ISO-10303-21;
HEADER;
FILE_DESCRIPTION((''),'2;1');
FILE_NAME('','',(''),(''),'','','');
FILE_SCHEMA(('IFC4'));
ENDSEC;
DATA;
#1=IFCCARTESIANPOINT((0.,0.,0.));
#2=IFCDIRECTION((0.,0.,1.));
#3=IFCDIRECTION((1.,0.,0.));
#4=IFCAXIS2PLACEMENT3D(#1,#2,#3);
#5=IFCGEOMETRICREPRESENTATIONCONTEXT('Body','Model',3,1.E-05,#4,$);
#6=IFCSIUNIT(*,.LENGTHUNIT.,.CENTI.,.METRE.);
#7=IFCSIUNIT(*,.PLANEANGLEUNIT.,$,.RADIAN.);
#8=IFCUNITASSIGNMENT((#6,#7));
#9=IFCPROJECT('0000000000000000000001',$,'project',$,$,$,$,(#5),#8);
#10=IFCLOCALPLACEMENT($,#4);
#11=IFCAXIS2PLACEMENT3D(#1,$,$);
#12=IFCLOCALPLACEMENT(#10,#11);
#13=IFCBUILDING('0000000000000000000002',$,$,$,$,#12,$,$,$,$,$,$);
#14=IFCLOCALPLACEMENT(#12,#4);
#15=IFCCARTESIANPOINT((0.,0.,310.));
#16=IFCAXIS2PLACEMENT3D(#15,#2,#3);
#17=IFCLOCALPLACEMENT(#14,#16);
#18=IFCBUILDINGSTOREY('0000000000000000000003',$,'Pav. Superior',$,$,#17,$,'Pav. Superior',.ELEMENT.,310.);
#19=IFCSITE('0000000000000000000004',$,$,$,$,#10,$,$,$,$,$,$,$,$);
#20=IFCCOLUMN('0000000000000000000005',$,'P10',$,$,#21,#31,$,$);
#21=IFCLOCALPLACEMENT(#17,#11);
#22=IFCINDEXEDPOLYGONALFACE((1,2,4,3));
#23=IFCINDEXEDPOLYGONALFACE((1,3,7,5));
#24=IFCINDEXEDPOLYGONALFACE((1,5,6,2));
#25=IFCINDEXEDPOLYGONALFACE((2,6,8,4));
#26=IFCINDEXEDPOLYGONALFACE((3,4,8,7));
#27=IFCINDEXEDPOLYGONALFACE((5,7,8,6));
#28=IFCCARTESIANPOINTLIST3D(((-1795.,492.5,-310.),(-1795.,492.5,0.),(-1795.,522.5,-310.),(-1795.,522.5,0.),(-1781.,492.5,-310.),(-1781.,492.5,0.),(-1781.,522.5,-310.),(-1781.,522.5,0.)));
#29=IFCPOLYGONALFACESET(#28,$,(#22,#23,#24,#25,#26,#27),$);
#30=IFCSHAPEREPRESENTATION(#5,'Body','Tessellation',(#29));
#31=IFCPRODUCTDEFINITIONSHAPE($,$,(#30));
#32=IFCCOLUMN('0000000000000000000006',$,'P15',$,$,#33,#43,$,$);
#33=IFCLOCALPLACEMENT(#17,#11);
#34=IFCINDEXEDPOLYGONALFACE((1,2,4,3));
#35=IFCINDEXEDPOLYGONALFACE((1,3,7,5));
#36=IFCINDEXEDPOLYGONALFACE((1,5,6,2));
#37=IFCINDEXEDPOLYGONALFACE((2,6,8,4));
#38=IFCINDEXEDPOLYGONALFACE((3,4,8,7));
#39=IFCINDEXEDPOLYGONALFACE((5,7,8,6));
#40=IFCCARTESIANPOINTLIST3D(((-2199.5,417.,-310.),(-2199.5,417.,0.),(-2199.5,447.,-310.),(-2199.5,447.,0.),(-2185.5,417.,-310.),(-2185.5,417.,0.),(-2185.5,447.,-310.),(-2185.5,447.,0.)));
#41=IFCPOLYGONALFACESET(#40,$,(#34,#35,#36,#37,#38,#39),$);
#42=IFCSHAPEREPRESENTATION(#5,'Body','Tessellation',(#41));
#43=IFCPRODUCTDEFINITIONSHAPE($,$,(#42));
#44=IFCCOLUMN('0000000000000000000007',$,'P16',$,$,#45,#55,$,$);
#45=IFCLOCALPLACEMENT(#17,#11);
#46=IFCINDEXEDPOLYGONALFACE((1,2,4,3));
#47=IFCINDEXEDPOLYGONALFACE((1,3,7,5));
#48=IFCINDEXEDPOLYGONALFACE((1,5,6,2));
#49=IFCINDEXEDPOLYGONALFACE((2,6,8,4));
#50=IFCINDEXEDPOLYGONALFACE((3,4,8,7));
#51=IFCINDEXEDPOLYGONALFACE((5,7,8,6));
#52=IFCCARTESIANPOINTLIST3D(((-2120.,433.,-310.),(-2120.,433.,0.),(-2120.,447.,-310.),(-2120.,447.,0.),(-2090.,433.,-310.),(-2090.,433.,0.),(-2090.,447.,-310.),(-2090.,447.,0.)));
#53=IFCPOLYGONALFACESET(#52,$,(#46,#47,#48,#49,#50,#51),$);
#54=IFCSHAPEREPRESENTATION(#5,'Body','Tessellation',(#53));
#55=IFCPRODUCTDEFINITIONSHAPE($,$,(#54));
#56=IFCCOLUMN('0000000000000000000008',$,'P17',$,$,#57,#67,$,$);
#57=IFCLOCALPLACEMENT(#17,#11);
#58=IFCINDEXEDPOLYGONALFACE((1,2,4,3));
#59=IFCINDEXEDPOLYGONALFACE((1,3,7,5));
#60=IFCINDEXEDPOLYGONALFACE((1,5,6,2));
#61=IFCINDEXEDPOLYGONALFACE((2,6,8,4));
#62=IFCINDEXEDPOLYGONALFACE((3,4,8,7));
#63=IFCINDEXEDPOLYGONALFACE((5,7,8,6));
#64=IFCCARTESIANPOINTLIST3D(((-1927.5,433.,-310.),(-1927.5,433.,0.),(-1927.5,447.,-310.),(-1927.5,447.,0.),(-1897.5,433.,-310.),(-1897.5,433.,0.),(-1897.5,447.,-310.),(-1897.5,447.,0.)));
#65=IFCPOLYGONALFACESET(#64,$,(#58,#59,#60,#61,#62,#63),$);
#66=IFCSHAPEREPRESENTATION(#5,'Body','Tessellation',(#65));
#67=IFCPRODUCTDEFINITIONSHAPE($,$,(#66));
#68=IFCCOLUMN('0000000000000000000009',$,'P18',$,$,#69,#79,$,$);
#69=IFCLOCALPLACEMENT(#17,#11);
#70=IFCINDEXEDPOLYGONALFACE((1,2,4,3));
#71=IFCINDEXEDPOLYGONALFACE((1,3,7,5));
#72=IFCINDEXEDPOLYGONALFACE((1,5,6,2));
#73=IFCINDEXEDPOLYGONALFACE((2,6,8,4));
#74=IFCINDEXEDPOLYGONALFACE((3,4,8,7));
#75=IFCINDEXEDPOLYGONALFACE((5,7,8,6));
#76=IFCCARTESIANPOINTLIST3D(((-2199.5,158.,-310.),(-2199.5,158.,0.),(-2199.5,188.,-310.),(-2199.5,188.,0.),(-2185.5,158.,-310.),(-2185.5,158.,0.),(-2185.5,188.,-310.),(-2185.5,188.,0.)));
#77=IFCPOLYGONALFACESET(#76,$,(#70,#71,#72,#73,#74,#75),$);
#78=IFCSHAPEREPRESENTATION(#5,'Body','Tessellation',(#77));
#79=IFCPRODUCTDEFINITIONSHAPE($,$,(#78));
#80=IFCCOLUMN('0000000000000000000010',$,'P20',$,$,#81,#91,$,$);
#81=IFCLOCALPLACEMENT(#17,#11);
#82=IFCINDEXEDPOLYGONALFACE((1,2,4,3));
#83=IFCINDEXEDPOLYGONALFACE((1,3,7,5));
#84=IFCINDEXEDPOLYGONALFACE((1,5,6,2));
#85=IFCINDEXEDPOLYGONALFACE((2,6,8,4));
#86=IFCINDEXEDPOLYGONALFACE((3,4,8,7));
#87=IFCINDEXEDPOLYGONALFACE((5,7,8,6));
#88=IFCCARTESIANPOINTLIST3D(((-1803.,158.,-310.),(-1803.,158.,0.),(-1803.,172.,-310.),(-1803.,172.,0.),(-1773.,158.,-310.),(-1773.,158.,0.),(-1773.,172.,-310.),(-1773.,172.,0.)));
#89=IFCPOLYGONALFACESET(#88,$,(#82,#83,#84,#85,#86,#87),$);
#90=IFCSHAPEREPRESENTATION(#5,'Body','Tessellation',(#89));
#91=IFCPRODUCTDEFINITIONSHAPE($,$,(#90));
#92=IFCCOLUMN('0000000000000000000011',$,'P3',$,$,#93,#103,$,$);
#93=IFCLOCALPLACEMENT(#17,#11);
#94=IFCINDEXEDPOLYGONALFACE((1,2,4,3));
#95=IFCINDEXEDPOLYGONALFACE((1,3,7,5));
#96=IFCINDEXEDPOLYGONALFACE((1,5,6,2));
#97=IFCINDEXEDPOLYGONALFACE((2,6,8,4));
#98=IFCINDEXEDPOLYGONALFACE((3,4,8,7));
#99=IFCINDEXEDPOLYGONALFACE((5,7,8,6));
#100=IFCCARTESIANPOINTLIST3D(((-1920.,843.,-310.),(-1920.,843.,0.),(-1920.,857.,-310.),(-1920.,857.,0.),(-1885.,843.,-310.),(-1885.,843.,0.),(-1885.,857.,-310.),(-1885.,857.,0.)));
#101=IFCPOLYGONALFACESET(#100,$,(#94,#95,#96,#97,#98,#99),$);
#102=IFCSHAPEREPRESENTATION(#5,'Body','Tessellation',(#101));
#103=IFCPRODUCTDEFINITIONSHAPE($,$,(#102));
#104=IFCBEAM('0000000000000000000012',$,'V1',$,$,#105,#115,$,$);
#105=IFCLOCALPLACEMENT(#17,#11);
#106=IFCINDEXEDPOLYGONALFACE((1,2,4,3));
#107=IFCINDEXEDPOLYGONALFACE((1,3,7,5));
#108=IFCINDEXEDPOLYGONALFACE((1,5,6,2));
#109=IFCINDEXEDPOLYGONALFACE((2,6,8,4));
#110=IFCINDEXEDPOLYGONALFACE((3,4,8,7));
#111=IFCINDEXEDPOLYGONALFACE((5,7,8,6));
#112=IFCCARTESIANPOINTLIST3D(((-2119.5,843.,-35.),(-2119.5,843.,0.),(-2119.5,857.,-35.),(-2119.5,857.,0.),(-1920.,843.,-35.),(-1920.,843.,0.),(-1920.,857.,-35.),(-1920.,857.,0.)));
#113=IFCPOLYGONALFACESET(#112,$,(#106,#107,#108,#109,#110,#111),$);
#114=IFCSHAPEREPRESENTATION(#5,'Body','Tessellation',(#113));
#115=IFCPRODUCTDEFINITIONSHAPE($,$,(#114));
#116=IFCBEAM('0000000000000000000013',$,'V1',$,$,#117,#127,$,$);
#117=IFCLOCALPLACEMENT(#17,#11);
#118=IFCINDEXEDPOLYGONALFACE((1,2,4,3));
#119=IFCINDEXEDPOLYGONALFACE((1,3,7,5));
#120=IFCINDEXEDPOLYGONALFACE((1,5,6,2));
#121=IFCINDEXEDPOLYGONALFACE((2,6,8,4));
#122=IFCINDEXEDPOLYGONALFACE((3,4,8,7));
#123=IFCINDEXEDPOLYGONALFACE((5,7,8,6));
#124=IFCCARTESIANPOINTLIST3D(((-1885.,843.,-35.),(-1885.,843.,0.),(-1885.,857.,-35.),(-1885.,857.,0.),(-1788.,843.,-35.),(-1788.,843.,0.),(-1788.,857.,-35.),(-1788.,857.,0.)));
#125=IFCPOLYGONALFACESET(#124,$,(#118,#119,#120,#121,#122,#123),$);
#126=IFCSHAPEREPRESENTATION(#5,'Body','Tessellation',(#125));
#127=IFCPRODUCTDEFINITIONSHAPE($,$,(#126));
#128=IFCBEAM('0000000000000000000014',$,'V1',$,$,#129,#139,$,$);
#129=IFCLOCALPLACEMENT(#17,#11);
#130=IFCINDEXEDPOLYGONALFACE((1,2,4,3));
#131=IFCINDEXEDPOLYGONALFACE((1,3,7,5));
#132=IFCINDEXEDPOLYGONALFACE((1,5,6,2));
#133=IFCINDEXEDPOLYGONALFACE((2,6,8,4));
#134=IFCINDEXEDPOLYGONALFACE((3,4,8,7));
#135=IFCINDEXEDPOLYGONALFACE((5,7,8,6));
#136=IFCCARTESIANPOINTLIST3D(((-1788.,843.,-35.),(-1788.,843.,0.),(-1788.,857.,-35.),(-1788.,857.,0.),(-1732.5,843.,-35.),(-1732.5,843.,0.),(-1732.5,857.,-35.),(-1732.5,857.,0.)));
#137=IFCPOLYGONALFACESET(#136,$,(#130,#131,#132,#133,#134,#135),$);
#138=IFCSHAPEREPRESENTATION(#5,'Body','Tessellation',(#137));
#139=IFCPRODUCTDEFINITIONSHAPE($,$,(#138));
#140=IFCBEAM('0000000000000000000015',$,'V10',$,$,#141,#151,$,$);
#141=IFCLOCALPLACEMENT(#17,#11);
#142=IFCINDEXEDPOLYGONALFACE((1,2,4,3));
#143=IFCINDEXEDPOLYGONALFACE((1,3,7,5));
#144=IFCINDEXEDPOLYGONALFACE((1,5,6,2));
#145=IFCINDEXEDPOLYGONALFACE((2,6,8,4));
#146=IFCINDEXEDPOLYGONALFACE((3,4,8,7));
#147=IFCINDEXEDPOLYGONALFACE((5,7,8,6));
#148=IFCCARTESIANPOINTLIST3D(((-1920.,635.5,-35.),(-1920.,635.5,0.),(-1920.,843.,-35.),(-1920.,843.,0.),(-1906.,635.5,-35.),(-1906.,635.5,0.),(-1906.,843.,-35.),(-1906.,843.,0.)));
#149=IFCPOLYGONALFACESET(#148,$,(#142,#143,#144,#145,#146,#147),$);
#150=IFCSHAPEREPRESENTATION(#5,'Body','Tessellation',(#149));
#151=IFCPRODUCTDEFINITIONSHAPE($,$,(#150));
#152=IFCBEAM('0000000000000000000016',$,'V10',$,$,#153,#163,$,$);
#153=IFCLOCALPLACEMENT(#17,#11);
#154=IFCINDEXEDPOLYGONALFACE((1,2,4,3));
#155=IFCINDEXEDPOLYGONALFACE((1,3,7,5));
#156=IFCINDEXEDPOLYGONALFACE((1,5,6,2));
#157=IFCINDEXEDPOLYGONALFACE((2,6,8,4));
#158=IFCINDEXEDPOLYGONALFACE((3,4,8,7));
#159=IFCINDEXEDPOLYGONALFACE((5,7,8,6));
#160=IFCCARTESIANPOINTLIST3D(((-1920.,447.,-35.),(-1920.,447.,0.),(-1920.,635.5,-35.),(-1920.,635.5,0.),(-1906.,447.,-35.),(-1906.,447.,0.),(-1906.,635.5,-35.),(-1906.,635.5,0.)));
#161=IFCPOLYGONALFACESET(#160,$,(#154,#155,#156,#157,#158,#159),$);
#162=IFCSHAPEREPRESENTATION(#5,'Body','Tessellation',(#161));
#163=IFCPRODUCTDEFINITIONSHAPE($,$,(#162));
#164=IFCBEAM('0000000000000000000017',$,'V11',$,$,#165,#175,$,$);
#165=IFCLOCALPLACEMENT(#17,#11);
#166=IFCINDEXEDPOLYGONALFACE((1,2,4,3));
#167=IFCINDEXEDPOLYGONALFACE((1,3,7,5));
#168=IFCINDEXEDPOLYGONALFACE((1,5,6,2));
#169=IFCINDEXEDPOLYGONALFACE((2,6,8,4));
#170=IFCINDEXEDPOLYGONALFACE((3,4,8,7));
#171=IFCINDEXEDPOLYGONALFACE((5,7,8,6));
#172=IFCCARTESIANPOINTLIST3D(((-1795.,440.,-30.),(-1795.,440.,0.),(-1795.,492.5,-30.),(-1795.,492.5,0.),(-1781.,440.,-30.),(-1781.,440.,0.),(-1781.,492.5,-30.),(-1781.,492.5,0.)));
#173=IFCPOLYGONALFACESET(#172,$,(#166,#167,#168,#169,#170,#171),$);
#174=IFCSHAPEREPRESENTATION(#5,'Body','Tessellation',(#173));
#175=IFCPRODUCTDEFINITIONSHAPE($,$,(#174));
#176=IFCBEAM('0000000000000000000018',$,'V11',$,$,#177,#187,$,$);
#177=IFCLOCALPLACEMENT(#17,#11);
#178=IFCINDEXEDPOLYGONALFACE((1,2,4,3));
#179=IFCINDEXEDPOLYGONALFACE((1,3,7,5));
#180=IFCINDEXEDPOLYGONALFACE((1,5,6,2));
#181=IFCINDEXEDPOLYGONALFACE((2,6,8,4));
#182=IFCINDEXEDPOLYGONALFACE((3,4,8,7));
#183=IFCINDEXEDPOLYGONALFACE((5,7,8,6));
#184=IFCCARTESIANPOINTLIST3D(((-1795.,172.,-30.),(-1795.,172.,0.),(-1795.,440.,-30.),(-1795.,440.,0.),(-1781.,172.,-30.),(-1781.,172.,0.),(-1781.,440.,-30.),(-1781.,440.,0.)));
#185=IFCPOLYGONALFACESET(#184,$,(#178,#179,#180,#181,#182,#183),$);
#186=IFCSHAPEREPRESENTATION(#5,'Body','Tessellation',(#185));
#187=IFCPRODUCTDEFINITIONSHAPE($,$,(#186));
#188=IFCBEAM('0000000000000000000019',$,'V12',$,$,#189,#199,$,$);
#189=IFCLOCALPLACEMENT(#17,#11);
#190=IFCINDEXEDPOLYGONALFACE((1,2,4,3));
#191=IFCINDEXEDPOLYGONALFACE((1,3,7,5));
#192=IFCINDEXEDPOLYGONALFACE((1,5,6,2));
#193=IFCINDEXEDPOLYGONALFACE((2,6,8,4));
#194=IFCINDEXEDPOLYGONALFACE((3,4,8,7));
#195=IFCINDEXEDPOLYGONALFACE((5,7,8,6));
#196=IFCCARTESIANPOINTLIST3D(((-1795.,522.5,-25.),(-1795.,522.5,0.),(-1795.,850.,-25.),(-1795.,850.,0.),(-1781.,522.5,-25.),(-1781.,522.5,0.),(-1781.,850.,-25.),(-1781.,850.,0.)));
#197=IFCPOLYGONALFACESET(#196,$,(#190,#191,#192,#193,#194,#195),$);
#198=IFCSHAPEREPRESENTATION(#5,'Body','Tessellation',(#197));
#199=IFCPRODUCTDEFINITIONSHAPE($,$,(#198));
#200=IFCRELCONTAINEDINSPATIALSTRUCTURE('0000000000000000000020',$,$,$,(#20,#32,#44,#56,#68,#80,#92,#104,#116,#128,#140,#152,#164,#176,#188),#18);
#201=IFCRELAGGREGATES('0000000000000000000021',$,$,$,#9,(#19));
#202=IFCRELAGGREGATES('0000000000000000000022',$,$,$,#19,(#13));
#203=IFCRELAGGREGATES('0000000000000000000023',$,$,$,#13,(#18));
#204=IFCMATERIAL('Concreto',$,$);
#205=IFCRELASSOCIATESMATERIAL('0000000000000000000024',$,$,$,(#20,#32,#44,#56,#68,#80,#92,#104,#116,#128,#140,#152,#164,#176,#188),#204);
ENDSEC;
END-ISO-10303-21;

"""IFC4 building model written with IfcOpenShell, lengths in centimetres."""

from ifc_helpers import new_model, si_unit, frame, origin, origin_with_axes, origin_2d_with_axis, place, context, project, spatial, rectangle, extrude, material, element, save


model = new_model("IFC4")

# Units and contexts
model_context = context("Model", 3, precision=1e-05, world=origin_with_axes(), identifier="Body")
ifc_project = project(units=[si_unit("LENGTHUNIT", "METRE", prefix="CENTI"), si_unit("PLANEANGLEUNIT", "RADIAN")], contexts=[model_context])

# Site, building, storey
site_placement = place(None, origin_with_axes())
site = spatial("IfcSite", under=ifc_project, at=site_placement)
building_placement = place(site_placement, origin())
building = spatial("IfcBuilding", under=site, at=building_placement)
placement = place(building_placement, origin_with_axes())
storey_placement = place(placement, frame((0.0, 0.0, 310.0), z_axis=(0.0, 0.0, 1.0), x_axis=(1.0, 0.0, 0.0)))
storey = spatial("IfcBuildingStorey", under=building, at=storey_placement, Name="Pav. Superior", LongName="Pav. Superior", CompositionType="ELEMENT", Elevation=310.0)

# Columns
ifc_material = material(Name="Concreto")
column_1_placement = place(storey_placement, frame((-1788.0, 507.5, 0.0), z_axis=(0.0, 0.0, 1.0), x_axis=(1.0, 0.0, 0.0)))
element("IfcColumn", 1, at=column_1_placement, inside=storey, material=ifc_material, Name="P10", context=model_context, shape_type="SolidModel", body=[
    extrude(rectangle(XDim=14.0, YDim=30.0, at=origin_2d_with_axis()), origin_with_axes(), (0.0, 0.0, -1.0), 310.0),
])
column_2_placement = place(storey_placement, frame((-2192.5, 432.0, 0.0), z_axis=(0.0, 0.0, 1.0), x_axis=(1.0, 0.0, 0.0)))
element("IfcColumn", 2, at=column_2_placement, inside=storey, material=ifc_material, Name="P15", context=model_context, shape_type="SolidModel", body=[
    extrude(rectangle(XDim=14.0, YDim=30.0, at=origin_2d_with_axis()), frame((0.0, 0.0, 0.0), z_axis=(0.0, 0.0, 1.0), x_axis=(-1.0, 0.0, 0.0)), (0.0, 0.0, -1.0), 310.0),
])
for number, where, z_axis, x_axis, name in (
    (3, (-2105.0, 440.0, 0.0), (0.0, 0.0, 1.0), (1.0, 0.0, 0.0), "P16"),
    (4, (-1912.5, 440.0, 0.0), (0.0, 0.0, 1.0), (1.0, 0.0, 0.0), "P17"),
):
    element("IfcColumn", number, at=place(storey_placement, frame(where, z_axis=z_axis, x_axis=x_axis)), inside=storey, material=ifc_material, Name=name, context=model_context, shape_type="SolidModel", body=[
        extrude(rectangle(XDim=14.0, YDim=30.0, at=origin_2d_with_axis()), frame((0.0, 0.0, 0.0), z_axis=(0.0, 0.0, 1.0), x_axis=(0.0, 1.0, 0.0)), (0.0, 0.0, -1.0), 310.0),
    ])
column_3_placement = place(storey_placement, frame((-2192.5, 173.0, 0.0), z_axis=(0.0, 0.0, 1.0), x_axis=(1.0, 0.0, 0.0)))
element("IfcColumn", 5, at=column_3_placement, inside=storey, material=ifc_material, Name="P18", context=model_context, shape_type="SolidModel", body=[
    extrude(rectangle(XDim=14.0, YDim=30.0, at=origin_2d_with_axis()), origin_with_axes(), (0.0, 0.0, -1.0), 310.0),
])
column_4_placement = place(storey_placement, frame((-1788.0, 165.0, 0.0), z_axis=(0.0, 0.0, 1.0), x_axis=(1.0, 0.0, 0.0)))
element("IfcColumn", 6, at=column_4_placement, inside=storey, material=ifc_material, Name="P20", context=model_context, shape_type="SolidModel", body=[
    extrude(rectangle(XDim=14.0, YDim=30.0, at=origin_2d_with_axis()), frame((0.0, 0.0, 0.0), z_axis=(0.0, 0.0, 1.0), x_axis=(0.0, -1.0, 0.0)), (0.0, 0.0, -1.0), 310.0),
])
column_5_placement = place(storey_placement, frame((-1902.5, 850.0, 0.0), z_axis=(0.0, 0.0, 1.0), x_axis=(1.0, 0.0, 0.0)))
element("IfcColumn", 7, at=column_5_placement, inside=storey, material=ifc_material, Name="P3", context=model_context, shape_type="SolidModel", body=[
    extrude(rectangle(XDim=14.0, YDim=35.0, at=origin_2d_with_axis()), frame((0.0, 0.0, 0.0), z_axis=(0.0, 0.0, 1.0), x_axis=(0.0, 1.0, 0.0)), (0.0, 0.0, -1.0), 310.0),
])

# Beams
beam_1_placement = place(storey_placement, frame((-2019.75, 850.0, 0.0), z_axis=(0.0, 0.0, 1.0), x_axis=(1.0, 0.0, 0.0)))
element("IfcBeam", 8, at=beam_1_placement, inside=storey, material=ifc_material, Name="V1", context=model_context, shape_type="SolidModel", body=[
    extrude(rectangle(XDim=14.0, YDim=35.0, at=origin_2d_with_axis()), frame((-99.75, 0.0, -17.5), z_axis=(1.0, 0.0, 0.0), x_axis=(0.0, -1.0, 0.0)), (0.0, 0.0, 1.0), 199.5),
])
beam_2_placement = place(storey_placement, frame((-1836.5, 850.0, 0.0), z_axis=(0.0, 0.0, 1.0), x_axis=(1.0, 0.0, 0.0)))
element("IfcBeam", 9, at=beam_2_placement, inside=storey, material=ifc_material, Name="V1", context=model_context, shape_type="SolidModel", body=[
    extrude(rectangle(XDim=14.0, YDim=35.0, at=origin_2d_with_axis()), frame((-48.5, 0.0, -17.5), z_axis=(1.0, 0.0, 0.0), x_axis=(0.0, -1.0, 0.0)), (0.0, 0.0, 1.0), 97.0),
])
beam_3_placement = place(storey_placement, frame((-1760.25, 850.0, 0.0), z_axis=(0.0, 0.0, 1.0), x_axis=(1.0, 0.0, 0.0)))
element("IfcBeam", 10, at=beam_3_placement, inside=storey, material=ifc_material, Name="V1", context=model_context, shape_type="SolidModel", body=[
    extrude(rectangle(XDim=14.0, YDim=35.0, at=origin_2d_with_axis()), frame((-27.75, 0.0, -17.5), z_axis=(1.0, 0.0, 0.0), x_axis=(0.0, -1.0, 0.0)), (0.0, 0.0, 1.0), 55.5),
])
beam_4_placement = place(storey_placement, frame((-1913.0, 739.25, 0.0), z_axis=(0.0, 0.0, 1.0), x_axis=(1.0, 0.0, 0.0)))
element("IfcBeam", 11, at=beam_4_placement, inside=storey, material=ifc_material, Name="V10", context=model_context, shape_type="SolidModel", body=[
    extrude(rectangle(XDim=14.0, YDim=35.0, at=origin_2d_with_axis()), frame((0.0, -103.75, -17.5), z_axis=(0.0, 1.0, 0.0), x_axis=(-1.0, 0.0, 0.0)), (0.0, 0.0, 1.0), 207.5),
])
beam_5_placement = place(storey_placement, frame((-1913.0, 541.25, 0.0), z_axis=(0.0, 0.0, 1.0), x_axis=(1.0, 0.0, 0.0)))
element("IfcBeam", 12, at=beam_5_placement, inside=storey, material=ifc_material, Name="V10", context=model_context, shape_type="SolidModel", body=[
    extrude(rectangle(XDim=14.0, YDim=35.0, at=origin_2d_with_axis()), frame((0.0, -94.25, -17.5), z_axis=(0.0, 1.0, 0.0), x_axis=(-1.0, 0.0, 0.0)), (0.0, 0.0, 1.0), 188.5),
])
beam_6_placement = place(storey_placement, frame((-1788.0, 466.25, 0.0), z_axis=(0.0, 0.0, 1.0), x_axis=(1.0, 0.0, 0.0)))
element("IfcBeam", 13, at=beam_6_placement, inside=storey, material=ifc_material, Name="V11", context=model_context, shape_type="SolidModel", body=[
    extrude(rectangle(XDim=14.0, YDim=30.0, at=origin_2d_with_axis()), frame((0.0, -26.25, -15.0), z_axis=(0.0, 1.0, 0.0), x_axis=(-1.0, 0.0, 0.0)), (0.0, 0.0, 1.0), 52.5),
])
beam_7_placement = place(storey_placement, frame((-1788.0, 306.0, 0.0), z_axis=(0.0, 0.0, 1.0), x_axis=(1.0, 0.0, 0.0)))
element("IfcBeam", 14, at=beam_7_placement, inside=storey, material=ifc_material, Name="V11", context=model_context, shape_type="SolidModel", body=[
    extrude(rectangle(XDim=14.0, YDim=30.0, at=origin_2d_with_axis()), frame((0.0, -134.0, -15.0), z_axis=(0.0, 1.0, 0.0), x_axis=(-1.0, 0.0, 0.0)), (0.0, 0.0, 1.0), 268.0),
])
beam_8_placement = place(storey_placement, frame((-1788.0, 686.25, 0.0), z_axis=(0.0, 0.0, 1.0), x_axis=(1.0, 0.0, 0.0)))
element("IfcBeam", 15, at=beam_8_placement, inside=storey, material=ifc_material, Name="V12", context=model_context, shape_type="SolidModel", body=[
    extrude(rectangle(XDim=14.0, YDim=25.0, at=origin_2d_with_axis()), frame((0.0, -163.75, -12.5), z_axis=(0.0, 1.0, 0.0), x_axis=(-1.0, 0.0, 0.0)), (0.0, 0.0, 1.0), 327.5),
])

save(model, "model.ifc")
